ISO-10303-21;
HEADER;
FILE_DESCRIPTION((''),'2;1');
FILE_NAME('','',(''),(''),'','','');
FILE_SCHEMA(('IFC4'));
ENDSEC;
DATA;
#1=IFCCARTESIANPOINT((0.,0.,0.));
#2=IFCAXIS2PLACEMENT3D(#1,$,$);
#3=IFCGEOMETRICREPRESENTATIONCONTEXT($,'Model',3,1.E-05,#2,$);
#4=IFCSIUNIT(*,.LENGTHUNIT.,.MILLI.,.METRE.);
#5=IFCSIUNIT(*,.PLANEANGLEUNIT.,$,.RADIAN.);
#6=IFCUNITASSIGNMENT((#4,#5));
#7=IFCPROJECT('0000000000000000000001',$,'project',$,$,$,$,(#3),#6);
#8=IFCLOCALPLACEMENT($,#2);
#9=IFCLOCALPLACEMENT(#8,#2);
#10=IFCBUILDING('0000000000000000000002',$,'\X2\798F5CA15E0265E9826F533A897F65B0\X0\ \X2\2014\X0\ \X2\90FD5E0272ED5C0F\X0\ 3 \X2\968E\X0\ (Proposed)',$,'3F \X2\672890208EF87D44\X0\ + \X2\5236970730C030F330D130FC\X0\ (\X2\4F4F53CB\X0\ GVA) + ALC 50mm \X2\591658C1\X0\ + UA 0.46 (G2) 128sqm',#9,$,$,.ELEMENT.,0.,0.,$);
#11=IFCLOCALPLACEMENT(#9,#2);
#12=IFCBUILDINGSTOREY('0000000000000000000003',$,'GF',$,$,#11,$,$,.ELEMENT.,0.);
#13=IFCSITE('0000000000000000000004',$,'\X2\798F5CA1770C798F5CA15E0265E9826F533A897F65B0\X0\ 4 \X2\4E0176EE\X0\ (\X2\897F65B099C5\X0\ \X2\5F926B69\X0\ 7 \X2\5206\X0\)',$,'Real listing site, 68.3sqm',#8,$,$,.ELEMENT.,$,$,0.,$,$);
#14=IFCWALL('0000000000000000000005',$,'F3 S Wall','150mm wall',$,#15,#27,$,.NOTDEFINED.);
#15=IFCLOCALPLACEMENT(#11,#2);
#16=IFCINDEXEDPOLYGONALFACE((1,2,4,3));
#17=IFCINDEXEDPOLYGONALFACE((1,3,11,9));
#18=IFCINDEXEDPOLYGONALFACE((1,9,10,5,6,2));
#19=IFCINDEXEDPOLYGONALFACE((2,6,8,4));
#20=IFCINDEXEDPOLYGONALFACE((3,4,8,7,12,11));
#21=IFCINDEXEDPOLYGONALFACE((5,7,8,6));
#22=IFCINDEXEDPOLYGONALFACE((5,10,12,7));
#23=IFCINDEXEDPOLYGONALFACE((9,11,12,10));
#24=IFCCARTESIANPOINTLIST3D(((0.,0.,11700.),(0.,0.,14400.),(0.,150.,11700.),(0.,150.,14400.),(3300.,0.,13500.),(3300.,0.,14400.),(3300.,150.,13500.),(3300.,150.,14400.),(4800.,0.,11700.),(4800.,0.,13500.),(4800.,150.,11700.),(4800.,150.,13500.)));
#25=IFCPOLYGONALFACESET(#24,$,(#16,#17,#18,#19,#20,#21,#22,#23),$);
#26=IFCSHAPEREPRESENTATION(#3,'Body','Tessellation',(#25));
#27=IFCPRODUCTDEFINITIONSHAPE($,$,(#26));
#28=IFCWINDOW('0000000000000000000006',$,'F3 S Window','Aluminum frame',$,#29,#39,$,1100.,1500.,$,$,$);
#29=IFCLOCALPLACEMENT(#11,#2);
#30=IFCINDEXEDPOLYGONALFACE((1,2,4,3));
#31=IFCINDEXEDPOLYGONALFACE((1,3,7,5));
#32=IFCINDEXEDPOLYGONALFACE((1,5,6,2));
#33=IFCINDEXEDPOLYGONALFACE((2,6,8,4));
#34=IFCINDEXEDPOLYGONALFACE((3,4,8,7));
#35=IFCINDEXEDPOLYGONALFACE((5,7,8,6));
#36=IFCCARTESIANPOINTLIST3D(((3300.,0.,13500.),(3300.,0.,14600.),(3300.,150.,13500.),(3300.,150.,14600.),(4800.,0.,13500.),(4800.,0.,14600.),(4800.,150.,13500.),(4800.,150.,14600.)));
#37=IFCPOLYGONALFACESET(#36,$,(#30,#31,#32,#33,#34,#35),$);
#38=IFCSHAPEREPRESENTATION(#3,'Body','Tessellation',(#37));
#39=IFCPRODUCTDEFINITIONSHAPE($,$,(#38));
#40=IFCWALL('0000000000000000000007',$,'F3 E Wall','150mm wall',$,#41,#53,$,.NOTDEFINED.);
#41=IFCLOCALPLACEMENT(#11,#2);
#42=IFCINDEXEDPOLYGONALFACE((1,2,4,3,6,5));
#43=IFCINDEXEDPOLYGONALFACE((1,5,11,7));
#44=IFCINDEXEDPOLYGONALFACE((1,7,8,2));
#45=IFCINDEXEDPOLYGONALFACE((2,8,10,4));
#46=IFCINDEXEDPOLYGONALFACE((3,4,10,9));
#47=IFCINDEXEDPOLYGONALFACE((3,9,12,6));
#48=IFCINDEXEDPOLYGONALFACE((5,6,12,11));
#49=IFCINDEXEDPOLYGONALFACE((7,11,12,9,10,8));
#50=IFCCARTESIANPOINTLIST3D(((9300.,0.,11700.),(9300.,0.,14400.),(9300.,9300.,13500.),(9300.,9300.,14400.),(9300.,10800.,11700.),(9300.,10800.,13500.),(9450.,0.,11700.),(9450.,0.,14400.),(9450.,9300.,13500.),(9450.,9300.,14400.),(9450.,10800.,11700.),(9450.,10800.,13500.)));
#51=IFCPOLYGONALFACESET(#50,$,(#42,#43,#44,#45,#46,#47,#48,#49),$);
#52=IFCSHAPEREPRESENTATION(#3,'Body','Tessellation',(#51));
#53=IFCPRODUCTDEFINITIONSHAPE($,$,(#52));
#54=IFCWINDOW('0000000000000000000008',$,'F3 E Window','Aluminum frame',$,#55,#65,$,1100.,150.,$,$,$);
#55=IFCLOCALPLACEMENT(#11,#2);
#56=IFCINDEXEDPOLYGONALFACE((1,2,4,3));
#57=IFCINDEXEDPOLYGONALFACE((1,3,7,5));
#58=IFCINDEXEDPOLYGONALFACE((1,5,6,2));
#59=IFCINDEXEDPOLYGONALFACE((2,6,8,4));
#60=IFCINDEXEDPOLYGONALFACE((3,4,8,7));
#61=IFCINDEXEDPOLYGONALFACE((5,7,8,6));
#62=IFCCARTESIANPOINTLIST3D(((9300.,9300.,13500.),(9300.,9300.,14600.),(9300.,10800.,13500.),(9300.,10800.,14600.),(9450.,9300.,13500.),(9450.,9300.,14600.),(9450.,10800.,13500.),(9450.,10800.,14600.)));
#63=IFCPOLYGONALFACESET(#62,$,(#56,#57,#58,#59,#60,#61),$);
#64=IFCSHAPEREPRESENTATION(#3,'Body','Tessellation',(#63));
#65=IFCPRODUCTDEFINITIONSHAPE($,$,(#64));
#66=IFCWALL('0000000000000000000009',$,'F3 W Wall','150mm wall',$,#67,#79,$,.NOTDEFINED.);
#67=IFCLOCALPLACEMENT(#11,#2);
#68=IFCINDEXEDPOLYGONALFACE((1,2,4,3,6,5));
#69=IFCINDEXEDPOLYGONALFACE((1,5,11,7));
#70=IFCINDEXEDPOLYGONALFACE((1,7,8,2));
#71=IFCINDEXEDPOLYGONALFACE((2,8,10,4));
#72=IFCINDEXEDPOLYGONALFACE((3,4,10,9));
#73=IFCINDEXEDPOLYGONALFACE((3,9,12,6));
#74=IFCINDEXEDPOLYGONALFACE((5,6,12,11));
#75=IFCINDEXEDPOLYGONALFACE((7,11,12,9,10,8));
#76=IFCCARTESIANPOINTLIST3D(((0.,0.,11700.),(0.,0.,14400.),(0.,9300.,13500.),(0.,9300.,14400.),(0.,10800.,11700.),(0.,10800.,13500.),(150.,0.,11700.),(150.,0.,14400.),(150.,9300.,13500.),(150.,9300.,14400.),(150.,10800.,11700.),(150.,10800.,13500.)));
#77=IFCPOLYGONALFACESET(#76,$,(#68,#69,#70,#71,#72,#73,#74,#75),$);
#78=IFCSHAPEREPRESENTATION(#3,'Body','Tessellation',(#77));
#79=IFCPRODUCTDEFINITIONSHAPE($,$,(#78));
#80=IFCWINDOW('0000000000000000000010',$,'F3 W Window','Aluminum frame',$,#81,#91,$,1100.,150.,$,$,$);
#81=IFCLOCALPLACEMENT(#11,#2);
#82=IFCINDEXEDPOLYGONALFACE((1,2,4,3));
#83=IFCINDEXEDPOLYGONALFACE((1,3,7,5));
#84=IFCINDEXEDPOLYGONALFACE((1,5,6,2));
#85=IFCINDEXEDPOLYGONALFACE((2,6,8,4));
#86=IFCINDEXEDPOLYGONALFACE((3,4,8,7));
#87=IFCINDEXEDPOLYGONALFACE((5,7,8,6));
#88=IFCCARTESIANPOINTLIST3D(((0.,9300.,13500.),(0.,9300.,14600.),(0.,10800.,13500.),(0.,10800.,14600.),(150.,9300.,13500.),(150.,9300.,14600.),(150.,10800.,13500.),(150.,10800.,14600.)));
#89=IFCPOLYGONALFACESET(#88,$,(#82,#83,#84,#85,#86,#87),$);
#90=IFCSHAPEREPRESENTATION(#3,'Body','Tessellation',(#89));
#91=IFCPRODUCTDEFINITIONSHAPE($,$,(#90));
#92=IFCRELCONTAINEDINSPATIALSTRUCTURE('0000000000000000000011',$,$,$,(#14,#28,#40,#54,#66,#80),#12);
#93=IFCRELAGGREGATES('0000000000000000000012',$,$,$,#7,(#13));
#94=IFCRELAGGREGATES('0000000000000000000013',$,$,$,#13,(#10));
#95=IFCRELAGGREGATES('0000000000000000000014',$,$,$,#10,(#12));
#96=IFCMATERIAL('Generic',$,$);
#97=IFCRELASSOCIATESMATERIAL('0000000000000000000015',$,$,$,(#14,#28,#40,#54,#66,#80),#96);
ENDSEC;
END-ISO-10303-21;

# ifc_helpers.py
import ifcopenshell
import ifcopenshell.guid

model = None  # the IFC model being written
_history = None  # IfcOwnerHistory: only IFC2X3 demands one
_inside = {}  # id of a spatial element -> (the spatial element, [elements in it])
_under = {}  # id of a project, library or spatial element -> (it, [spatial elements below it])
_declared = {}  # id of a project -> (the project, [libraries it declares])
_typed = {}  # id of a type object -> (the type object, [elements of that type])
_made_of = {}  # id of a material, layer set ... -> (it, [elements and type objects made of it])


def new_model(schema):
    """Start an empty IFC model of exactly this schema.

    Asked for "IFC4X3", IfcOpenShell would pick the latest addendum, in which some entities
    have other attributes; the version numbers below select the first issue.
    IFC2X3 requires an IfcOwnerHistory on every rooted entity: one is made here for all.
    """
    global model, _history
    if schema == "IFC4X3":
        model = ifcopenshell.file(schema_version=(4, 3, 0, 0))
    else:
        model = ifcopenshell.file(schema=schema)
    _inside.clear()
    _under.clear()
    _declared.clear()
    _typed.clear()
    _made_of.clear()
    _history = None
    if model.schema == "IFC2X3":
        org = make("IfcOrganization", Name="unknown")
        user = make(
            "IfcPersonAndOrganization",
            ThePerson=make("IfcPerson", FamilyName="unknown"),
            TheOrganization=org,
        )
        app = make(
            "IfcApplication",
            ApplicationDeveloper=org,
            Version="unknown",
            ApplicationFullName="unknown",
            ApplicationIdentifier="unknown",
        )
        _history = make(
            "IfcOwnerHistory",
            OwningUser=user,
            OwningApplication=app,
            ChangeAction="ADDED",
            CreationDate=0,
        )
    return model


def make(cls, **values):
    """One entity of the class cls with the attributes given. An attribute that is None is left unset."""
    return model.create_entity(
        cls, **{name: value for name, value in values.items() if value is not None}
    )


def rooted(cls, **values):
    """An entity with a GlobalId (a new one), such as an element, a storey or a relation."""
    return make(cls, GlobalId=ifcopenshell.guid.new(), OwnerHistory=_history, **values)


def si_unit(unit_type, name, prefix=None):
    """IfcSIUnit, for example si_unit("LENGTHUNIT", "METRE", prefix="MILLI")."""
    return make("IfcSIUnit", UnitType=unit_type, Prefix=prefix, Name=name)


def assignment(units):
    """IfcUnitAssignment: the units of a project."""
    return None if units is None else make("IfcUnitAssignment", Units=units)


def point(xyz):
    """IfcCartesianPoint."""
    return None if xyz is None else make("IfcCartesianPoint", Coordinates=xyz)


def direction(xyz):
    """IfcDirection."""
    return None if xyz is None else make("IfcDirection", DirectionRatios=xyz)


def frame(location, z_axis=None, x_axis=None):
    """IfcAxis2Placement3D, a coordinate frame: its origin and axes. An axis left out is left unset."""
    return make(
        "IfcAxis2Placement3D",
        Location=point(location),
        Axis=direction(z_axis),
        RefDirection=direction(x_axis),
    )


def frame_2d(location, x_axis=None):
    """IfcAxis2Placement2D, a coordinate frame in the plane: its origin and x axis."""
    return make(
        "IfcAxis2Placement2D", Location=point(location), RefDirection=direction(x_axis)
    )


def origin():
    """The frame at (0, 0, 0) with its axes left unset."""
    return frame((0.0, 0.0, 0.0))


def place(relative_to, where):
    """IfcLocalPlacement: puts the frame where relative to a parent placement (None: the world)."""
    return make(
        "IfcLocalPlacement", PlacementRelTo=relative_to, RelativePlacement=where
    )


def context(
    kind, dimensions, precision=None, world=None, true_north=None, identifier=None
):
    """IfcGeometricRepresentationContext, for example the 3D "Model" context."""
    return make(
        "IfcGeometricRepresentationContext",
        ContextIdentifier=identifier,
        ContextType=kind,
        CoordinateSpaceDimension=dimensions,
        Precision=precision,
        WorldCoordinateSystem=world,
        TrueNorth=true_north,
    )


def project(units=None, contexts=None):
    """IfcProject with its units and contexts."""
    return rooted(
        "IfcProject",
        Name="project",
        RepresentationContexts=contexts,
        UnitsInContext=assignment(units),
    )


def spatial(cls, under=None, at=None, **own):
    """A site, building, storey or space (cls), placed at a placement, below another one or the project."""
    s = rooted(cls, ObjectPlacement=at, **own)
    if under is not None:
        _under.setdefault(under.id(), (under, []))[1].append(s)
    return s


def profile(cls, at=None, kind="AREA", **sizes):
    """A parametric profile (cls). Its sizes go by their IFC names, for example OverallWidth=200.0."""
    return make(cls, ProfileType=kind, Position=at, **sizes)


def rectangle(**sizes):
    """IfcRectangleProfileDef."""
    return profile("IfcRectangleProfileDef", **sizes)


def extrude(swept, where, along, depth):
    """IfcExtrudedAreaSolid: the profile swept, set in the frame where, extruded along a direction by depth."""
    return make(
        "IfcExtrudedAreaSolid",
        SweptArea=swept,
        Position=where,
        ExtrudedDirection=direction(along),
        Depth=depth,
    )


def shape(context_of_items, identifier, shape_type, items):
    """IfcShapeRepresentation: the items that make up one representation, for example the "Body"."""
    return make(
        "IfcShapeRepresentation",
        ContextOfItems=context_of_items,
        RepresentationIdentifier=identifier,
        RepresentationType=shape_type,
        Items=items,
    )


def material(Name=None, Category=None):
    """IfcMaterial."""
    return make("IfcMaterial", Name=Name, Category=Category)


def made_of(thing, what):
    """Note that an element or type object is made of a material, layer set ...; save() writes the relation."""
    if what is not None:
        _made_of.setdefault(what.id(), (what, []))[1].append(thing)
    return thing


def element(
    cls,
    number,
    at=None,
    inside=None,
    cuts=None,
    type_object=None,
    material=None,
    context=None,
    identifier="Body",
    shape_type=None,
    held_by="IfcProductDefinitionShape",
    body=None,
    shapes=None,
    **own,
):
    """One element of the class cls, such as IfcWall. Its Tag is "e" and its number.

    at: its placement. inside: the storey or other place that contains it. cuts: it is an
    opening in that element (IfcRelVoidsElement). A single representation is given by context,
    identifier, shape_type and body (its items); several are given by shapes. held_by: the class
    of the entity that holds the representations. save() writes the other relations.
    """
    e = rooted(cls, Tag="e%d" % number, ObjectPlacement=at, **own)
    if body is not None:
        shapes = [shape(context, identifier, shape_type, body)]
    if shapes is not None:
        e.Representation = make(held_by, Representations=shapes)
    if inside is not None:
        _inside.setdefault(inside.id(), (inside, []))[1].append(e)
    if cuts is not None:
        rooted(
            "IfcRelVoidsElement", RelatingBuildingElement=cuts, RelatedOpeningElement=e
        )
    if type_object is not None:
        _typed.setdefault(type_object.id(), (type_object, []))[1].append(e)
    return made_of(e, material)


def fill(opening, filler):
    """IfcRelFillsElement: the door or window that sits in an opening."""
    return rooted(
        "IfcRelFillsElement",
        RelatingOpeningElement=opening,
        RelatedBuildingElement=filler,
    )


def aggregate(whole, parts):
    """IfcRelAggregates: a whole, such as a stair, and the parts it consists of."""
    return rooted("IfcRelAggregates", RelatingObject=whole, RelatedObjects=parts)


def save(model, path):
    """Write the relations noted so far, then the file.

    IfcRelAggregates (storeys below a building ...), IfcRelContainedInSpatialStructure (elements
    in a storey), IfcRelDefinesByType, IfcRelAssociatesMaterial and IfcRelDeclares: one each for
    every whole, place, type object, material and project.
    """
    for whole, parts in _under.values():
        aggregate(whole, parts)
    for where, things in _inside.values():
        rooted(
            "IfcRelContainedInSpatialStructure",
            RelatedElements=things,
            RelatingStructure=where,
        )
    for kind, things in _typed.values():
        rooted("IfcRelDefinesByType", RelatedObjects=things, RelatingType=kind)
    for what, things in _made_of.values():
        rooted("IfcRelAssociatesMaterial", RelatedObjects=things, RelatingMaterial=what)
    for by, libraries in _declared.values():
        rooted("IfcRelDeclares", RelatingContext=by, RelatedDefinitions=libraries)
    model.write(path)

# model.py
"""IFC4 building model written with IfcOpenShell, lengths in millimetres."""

from ifc_helpers import new_model, si_unit, frame, frame_2d, origin, place, context, project, spatial, rectangle, extrude, material, element, fill, save


model = new_model("IFC4")

# Units and contexts
model_context = context("Model", 3, precision=1e-05, world=origin())
ifc_project = project(units=[si_unit("LENGTHUNIT", "METRE", prefix="MILLI"), si_unit("PLANEANGLEUNIT", "RADIAN")], contexts=[model_context])

# Site, building, storey
site_placement = place(None, origin())
site = spatial("IfcSite", under=ifc_project, at=site_placement, Name="福岡県福岡市早良区西新 4 丁目 (西新駅 徒歩 7 分)", ObjectType="Real listing site, 68.3sqm", CompositionType="ELEMENT", RefElevation=0.0)
building_placement = place(site_placement, origin())
building = spatial("IfcBuilding", under=site, at=building_placement, Name="福岡市早良区西新 — 都市狭小 3 階 (Proposed)", ObjectType="3F 木造軸組 + 制震ダンパー (住友 GVA) + ALC 50mm 外壁 + UA 0.46 (G2) 128sqm", CompositionType="ELEMENT", ElevationOfRefHeight=0.0, ElevationOfTerrain=0.0)
storey_placement = place(building_placement, origin())
storey = spatial("IfcBuildingStorey", under=building, at=storey_placement, Name="GF", CompositionType="ELEMENT", Elevation=0.0)

# Walls, openings, windows
ifc_material_1 = material(Name="Generic")
wall_1_placement = place(storey_placement, frame((0.0, 0.0, 5850.0)))
wall_1 = element("IfcWall", 1, at=wall_1_placement, inside=storey, material=ifc_material_1, Name="F3 S Wall", Description="150mm wall", PredefinedType="NOTDEFINED", context=model_context, shape_type="SweptSolid", body=[
    extrude(rectangle(XDim=4800.0, YDim=150.0, at=frame_2d((2400.0, 75.0))), frame((0.0, 0.0, 5850.0)), (0.0, 0.0, 1.0), 2700.0),
])
opening_1_placement = place(storey_placement, frame((1650.0, 0.0, 6750.0)))
opening_1 = element("IfcOpeningElement", 2, at=opening_1_placement, cuts=wall_1, PredefinedType="NOTDEFINED", context=model_context, shape_type="SweptSolid", body=[
    extrude(rectangle(XDim=1500.0, YDim=150.0, at=frame_2d((750.0, 75.0))), frame((1650.0, 0.0, 6750.0)), (0.0, 0.0, 1.0), 1100.0),
])
window_1_placement = place(storey_placement, frame((1650.0, 0.0, 6750.0)))
window_1 = element("IfcWindow", 3, at=window_1_placement, inside=storey, material=ifc_material_1, Name="F3 S Window", Description="Aluminum frame", OverallHeight=1100.0, OverallWidth=1500.0, context=model_context, shape_type="SweptSolid", body=[
    extrude(rectangle(XDim=1500.0, YDim=150.0, at=frame_2d((750.0, 75.0))), frame((1650.0, 0.0, 6750.0)), (0.0, 0.0, 1.0), 1100.0),
])
fill(opening_1, window_1)
wall_2_placement = place(storey_placement, frame((4650.0, 0.0, 5850.0)))
wall_2 = element("IfcWall", 4, at=wall_2_placement, inside=storey, material=ifc_material_1, Name="F3 E Wall", Description="150mm wall", PredefinedType="NOTDEFINED", context=model_context, shape_type="SweptSolid", body=[
    extrude(rectangle(XDim=150.0, YDim=10800.0, at=frame_2d((75.0, 5400.0))), frame((4650.0, 0.0, 5850.0)), (0.0, 0.0, 1.0), 2700.0),
])
opening_2_placement = place(storey_placement, frame((4650.0, 4650.0, 6750.0)))
opening_2 = element("IfcOpeningElement", 5, at=opening_2_placement, cuts=wall_2, PredefinedType="NOTDEFINED", context=model_context, shape_type="SweptSolid", body=[
    extrude(rectangle(XDim=150.0, YDim=1500.0, at=frame_2d((75.0, 750.0))), frame((4650.0, 4650.0, 6750.0)), (0.0, 0.0, 1.0), 1100.0),
])
window_2_placement = place(storey_placement, frame((4650.0, 4650.0, 6750.0)))
window_2 = element("IfcWindow", 6, at=window_2_placement, inside=storey, material=ifc_material_1, Name="F3 E Window", Description="Aluminum frame", OverallHeight=1100.0, OverallWidth=150.0, context=model_context, shape_type="SweptSolid", body=[
    extrude(rectangle(XDim=150.0, YDim=1500.0, at=frame_2d((75.0, 750.0))), frame((4650.0, 4650.0, 6750.0)), (0.0, 0.0, 1.0), 1100.0),
])
fill(opening_2, window_2)
wall_3_placement = place(storey_placement, frame((0.0, 0.0, 5850.0)))
wall_3 = element("IfcWall", 7, at=wall_3_placement, inside=storey, material=ifc_material_1, Name="F3 W Wall", Description="150mm wall", PredefinedType="NOTDEFINED", context=model_context, shape_type="SweptSolid", body=[
    extrude(rectangle(XDim=150.0, YDim=10800.0, at=frame_2d((75.0, 5400.0))), frame((0.0, 0.0, 5850.0)), (0.0, 0.0, 1.0), 2700.0),
])
opening_3_placement = place(storey_placement, frame((0.0, 4650.0, 6750.0)))
opening_3 = element("IfcOpeningElement", 8, at=opening_3_placement, cuts=wall_3, PredefinedType="NOTDEFINED", context=model_context, shape_type="SweptSolid", body=[
    extrude(rectangle(XDim=150.0, YDim=1500.0, at=frame_2d((75.0, 750.0))), frame((0.0, 4650.0, 6750.0)), (0.0, 0.0, 1.0), 1100.0),
])
window_3_placement = place(storey_placement, frame((0.0, 4650.0, 6750.0)))
window_3 = element("IfcWindow", 9, at=window_3_placement, inside=storey, material=ifc_material_1, Name="F3 W Window", Description="Aluminum frame", OverallHeight=1100.0, OverallWidth=150.0, context=model_context, shape_type="SweptSolid", body=[
    extrude(rectangle(XDim=150.0, YDim=1500.0, at=frame_2d((75.0, 750.0))), frame((0.0, 4650.0, 6750.0)), (0.0, 0.0, 1.0), 1100.0),
])
fill(opening_3, window_3)

save(model, "model.ifc")
